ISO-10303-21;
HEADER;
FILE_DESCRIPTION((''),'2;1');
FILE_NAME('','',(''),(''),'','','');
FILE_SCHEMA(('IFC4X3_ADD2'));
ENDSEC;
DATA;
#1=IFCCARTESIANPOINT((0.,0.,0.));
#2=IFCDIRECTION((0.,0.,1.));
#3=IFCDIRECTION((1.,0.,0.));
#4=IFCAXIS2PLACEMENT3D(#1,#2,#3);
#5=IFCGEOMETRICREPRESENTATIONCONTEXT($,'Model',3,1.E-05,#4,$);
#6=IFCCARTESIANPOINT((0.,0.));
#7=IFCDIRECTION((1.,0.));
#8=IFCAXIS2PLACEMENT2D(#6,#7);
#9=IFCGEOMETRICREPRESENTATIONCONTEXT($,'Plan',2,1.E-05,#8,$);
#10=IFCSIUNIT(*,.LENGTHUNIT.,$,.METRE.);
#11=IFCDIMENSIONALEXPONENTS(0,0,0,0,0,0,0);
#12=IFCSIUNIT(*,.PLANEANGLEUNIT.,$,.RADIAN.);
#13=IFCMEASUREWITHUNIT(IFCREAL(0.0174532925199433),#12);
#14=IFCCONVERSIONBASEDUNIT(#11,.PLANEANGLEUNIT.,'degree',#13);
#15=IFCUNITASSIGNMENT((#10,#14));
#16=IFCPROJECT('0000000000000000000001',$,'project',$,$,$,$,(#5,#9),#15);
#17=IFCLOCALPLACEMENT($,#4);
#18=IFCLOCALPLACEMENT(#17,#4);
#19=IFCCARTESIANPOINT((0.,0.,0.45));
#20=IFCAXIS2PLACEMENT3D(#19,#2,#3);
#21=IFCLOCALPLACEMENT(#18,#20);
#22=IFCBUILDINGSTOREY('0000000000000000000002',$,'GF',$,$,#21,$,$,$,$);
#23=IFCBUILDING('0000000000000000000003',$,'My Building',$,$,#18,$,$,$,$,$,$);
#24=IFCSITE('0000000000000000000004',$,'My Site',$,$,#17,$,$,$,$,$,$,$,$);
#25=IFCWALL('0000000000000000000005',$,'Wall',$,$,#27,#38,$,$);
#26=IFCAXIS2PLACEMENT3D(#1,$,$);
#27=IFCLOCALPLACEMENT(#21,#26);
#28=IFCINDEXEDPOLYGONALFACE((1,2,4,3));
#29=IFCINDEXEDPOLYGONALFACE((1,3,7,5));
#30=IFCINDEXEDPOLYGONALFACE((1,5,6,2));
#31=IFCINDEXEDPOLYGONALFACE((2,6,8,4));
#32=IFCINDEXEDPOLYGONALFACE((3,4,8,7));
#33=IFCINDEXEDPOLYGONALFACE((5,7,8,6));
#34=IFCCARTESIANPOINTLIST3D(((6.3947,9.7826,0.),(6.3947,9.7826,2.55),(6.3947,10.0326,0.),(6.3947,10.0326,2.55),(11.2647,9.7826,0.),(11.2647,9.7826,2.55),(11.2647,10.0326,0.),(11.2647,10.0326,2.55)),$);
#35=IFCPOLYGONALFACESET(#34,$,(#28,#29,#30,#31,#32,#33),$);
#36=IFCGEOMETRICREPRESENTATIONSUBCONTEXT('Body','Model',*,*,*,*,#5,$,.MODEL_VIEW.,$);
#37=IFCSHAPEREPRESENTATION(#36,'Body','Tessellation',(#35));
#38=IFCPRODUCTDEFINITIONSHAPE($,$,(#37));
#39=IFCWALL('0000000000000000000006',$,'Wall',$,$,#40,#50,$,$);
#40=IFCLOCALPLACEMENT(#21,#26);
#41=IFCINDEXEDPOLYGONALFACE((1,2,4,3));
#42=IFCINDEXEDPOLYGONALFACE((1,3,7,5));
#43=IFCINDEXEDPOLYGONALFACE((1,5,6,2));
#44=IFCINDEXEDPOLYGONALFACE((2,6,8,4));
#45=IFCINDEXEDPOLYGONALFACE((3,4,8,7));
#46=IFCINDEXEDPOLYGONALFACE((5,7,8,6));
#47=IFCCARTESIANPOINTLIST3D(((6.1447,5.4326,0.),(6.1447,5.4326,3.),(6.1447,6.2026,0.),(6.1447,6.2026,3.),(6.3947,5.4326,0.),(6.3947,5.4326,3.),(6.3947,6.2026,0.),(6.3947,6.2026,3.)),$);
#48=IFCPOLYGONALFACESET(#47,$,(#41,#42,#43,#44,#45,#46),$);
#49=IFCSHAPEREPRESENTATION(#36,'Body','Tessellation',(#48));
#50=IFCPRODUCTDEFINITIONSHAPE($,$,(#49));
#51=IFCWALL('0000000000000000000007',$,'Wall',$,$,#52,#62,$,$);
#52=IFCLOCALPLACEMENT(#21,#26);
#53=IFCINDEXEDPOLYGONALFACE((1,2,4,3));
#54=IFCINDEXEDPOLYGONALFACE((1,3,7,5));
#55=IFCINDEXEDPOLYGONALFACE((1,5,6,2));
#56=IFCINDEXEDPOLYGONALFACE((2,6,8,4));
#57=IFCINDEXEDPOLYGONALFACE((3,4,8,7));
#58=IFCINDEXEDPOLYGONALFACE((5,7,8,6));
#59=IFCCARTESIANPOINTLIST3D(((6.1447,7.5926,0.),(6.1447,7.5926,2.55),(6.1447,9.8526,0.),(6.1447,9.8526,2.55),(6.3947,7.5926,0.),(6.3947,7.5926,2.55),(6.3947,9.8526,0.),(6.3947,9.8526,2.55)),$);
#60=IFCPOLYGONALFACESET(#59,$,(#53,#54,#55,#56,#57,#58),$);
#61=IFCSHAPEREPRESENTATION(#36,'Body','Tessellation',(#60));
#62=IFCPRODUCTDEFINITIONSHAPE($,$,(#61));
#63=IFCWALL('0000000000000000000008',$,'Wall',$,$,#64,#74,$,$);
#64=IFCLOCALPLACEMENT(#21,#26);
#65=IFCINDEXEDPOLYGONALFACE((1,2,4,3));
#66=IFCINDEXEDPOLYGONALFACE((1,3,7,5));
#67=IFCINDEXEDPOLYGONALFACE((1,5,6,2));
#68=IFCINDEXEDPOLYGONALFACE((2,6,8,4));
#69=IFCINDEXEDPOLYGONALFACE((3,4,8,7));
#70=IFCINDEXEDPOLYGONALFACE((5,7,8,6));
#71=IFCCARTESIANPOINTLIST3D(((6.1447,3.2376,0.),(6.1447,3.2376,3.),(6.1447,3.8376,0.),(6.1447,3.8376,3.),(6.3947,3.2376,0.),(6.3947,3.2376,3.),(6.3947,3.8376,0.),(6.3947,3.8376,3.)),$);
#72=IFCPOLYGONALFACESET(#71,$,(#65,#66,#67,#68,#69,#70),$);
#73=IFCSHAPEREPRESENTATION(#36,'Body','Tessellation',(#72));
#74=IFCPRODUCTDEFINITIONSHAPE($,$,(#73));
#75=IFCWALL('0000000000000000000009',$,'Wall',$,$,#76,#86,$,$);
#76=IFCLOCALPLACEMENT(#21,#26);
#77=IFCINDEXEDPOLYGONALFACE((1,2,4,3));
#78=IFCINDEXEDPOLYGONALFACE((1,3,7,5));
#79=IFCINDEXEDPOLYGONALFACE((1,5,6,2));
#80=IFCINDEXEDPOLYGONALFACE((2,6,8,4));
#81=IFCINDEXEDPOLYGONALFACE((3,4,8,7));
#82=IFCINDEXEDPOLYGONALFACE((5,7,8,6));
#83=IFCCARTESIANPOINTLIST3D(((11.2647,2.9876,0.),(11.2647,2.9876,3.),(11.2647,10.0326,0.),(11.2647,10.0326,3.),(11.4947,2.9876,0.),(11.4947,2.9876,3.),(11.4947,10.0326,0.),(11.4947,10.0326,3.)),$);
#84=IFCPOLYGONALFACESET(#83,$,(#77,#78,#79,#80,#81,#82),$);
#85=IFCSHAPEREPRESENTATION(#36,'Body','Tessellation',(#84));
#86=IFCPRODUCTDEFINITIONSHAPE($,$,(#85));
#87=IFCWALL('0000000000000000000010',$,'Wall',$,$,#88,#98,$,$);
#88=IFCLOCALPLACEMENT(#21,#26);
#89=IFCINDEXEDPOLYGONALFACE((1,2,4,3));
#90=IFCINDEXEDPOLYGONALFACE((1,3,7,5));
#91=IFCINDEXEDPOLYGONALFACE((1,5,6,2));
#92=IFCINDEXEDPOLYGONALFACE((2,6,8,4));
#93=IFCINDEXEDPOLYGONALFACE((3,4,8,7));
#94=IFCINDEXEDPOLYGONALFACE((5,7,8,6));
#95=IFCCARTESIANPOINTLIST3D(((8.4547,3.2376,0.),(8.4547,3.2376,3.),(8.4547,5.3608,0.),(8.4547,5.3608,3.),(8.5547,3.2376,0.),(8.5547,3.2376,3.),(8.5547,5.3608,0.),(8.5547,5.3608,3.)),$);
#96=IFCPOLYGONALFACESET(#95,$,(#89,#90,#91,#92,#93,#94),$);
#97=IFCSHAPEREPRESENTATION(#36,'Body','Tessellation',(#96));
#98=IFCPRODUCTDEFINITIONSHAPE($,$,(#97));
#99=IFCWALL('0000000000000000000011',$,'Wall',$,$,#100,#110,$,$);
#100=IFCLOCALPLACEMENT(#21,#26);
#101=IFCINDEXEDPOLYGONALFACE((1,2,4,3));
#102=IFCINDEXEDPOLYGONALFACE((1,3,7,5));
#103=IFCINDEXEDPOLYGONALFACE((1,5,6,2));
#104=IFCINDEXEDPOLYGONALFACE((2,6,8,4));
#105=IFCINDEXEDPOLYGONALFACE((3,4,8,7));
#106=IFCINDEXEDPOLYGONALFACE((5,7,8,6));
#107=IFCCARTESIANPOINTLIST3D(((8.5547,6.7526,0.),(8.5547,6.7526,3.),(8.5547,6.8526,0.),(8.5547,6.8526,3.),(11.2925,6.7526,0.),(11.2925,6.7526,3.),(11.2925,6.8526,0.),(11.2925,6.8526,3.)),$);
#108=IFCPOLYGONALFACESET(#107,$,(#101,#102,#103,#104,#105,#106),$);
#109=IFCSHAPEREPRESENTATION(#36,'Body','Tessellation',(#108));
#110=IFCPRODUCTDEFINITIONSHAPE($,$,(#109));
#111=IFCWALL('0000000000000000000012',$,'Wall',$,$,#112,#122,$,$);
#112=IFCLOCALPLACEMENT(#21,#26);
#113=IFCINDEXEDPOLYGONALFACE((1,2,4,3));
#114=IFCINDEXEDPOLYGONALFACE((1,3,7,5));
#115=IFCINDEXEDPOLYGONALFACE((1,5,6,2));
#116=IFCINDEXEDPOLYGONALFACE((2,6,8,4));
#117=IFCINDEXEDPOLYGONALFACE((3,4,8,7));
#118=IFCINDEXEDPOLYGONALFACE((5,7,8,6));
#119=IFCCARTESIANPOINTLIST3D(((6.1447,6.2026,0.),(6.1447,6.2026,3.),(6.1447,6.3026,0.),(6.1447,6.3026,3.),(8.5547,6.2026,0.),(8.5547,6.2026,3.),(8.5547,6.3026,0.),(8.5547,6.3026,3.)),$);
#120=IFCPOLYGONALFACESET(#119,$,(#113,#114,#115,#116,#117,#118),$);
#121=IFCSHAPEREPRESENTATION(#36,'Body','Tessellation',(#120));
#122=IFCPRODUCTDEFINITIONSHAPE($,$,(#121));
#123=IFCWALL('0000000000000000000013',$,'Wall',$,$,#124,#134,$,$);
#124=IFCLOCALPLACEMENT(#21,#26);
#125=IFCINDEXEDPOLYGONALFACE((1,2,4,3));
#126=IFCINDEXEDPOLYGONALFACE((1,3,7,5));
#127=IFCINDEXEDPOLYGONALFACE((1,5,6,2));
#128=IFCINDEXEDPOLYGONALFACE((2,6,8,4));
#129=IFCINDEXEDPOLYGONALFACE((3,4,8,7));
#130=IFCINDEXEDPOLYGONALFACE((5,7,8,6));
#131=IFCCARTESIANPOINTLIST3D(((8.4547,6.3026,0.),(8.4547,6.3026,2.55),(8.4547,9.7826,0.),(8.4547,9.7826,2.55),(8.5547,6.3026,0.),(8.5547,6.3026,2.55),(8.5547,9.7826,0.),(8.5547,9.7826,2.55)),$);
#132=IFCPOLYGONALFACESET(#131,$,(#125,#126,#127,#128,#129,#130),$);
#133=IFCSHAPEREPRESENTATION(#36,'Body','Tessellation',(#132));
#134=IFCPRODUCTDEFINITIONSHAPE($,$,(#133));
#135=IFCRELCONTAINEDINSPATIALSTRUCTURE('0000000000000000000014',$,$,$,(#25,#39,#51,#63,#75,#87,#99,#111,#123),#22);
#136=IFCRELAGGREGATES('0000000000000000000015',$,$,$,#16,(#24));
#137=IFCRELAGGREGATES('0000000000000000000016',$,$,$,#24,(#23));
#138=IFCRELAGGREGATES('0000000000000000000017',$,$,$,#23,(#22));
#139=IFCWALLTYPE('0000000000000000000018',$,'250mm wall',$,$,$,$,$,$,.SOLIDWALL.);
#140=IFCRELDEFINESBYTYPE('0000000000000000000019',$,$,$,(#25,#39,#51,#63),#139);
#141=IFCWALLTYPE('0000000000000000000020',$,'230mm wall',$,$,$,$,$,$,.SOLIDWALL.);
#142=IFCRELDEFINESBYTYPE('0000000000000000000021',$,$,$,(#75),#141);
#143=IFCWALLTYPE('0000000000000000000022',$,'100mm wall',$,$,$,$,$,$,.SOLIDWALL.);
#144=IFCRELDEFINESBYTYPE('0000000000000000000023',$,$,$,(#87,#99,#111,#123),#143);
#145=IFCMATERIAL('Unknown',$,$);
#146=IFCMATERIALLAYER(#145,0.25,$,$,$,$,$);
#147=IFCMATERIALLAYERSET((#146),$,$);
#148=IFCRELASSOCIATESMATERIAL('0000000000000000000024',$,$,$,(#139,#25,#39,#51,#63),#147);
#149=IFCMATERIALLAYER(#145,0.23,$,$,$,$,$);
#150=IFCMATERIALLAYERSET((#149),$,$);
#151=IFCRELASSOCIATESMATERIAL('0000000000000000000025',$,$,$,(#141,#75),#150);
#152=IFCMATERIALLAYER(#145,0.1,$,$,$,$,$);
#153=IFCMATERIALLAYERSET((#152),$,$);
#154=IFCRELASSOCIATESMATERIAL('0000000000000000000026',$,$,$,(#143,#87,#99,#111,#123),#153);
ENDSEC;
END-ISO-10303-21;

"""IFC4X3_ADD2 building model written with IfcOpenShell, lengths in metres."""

from ifc_helpers import new_model, entity, si_unit, converted_unit, frame, origin_with_axes, origin_2d_with_axis, place, context, subcontext, project, spatial, indexed_curve, outline, extrude, clip, halfspace, material, layer, layer_set, layer_usage, type_object, element, save


model = new_model("IFC4X3_ADD2")

# Units and contexts
model_context = context("Model", 3, precision=1e-05, world=origin_with_axes())
plan_context = context("Plan", 2, precision=1e-05, world=origin_2d_with_axis())
body_context_1 = subcontext(model_context, "Body", "Model", "MODEL_VIEW")
ifc_project = project(units=[si_unit("LENGTHUNIT", "METRE"), converted_unit("PLANEANGLEUNIT", "degree", entity("IfcReal", 0.0174532925199433), si_unit("PLANEANGLEUNIT", "RADIAN"), dimensions=[0, 0, 0, 0, 0, 0, 0])], contexts=[model_context, plan_context])

# Site, building, storey
site_placement = place(None, origin_with_axes())
site = spatial("IfcSite", under=ifc_project, at=site_placement, Name="My Site")
building_placement = place(site_placement, origin_with_axes())
building = spatial("IfcBuilding", under=site, at=building_placement, Name="My Building")
storey_placement = place(building_placement, frame((0.0, 0.0, 0.45), z_axis=(0.0, 0.0, 1.0), x_axis=(1.0, 0.0, 0.0)))
storey = spatial("IfcBuildingStorey", under=building, at=storey_placement, Name="GF")

# Shared definitions
ifc_material_1 = material(Name="Unknown")

# Shared definitions
ifc_layer_1 = layer(ifc_material_1, 0.25)
ifc_layer_set_1 = layer_set([ifc_layer_1])
wall_type_1 = type_object("IfcWallType", Name="250mm wall", PredefinedType="SOLIDWALL", material=ifc_layer_set_1)

# Walls
ifc_layer_usage_1 = layer_usage(ifc_layer_set_1, "AXIS2", "POSITIVE", 0.0)
wall_1_placement = place(storey_placement, frame((6.3947, 9.7826, 0.0), z_axis=(0.0, 0.0, 1.0), x_axis=(1.0, 0.0, 0.0)))
element("IfcWall", 1, at=wall_1_placement, inside=storey, type_object=wall_type_1, material=ifc_layer_usage_1, Name="Wall", context=body_context_1, shape_type="Clipping", body=[
    clip(extrude(outline(indexed_curve([(0.0, 0.0), (0.0, 0.25), (4.87, 0.25), (4.87, 0.0), (0.0, 0.0)], self_intersect=False)), origin_with_axes(), (0.0, 0.0, 1.0), 2.55), halfspace(frame((0.0, 0.0, 2.55), z_axis=(0.0, 0.0, 1.0), x_axis=(-1.0, 0.0, 0.0)), False)),
])
ifc_layer_usage_2 = layer_usage(ifc_layer_set_1, "AXIS2", "POSITIVE", 0.0)
wall_2_placement = place(storey_placement, frame((6.3947, 5.4326, 0.0), z_axis=(0.0, 0.0, 1.0), x_axis=(0.0, 1.0, 0.0)))
element("IfcWall", 2, at=wall_2_placement, inside=storey, type_object=wall_type_1, material=ifc_layer_usage_2, Name="Wall", context=body_context_1, shape_type="SweptSolid", body=[
    extrude(outline(indexed_curve([(0.0, 0.0), (0.0, 0.25), (0.77, 0.25), (0.77, 0.0), (0.0, 0.0)], self_intersect=False)), origin_with_axes(), (0.0, 0.0, 1.0), 3.0),
])
ifc_layer_usage_3 = layer_usage(ifc_layer_set_1, "AXIS2", "POSITIVE", 0.0)
wall_3_placement = place(storey_placement, frame((6.3947, 7.5926, 0.0), z_axis=(0.0, 0.0, 1.0), x_axis=(0.0, 1.0, 0.0)))
element("IfcWall", 3, at=wall_3_placement, inside=storey, type_object=wall_type_1, material=ifc_layer_usage_3, Name="Wall", context=body_context_1, shape_type="Clipping", body=[
    clip(extrude(outline(indexed_curve([(0.0, 0.0), (0.0, 0.25), (2.26, 0.25), (2.26, 0.0), (0.0, 0.0)], self_intersect=False)), origin_with_axes(), (0.0, 0.0, 1.0), 2.55), halfspace(frame((0.0, 0.0, 2.55), z_axis=(0.0, 0.0, 1.0), x_axis=(-1.0, 0.0, 0.0)), False)),
])
ifc_layer_usage_4 = layer_usage(ifc_layer_set_1, "AXIS2", "POSITIVE", 0.0)
wall_4_placement = place(storey_placement, frame((6.3947, 3.2376, 0.0), z_axis=(0.0, 0.0, 1.0), x_axis=(0.0, 1.0, 0.0)))
element("IfcWall", 4, at=wall_4_placement, inside=storey, type_object=wall_type_1, material=ifc_layer_usage_4, Name="Wall", context=body_context_1, shape_type="SweptSolid", body=[
    extrude(outline(indexed_curve([(0.0, 0.0), (0.0, 0.25), (0.6, 0.25), (0.6, 0.0), (0.0, 0.0)], self_intersect=False)), origin_with_axes(), (0.0, 0.0, 1.0), 3.0),
])
ifc_layer_2 = layer(ifc_material_1, 0.23)
ifc_layer_set_2 = layer_set([ifc_layer_2])
ifc_layer_usage_5 = layer_usage(ifc_layer_set_2, "AXIS2", "POSITIVE", 0.0)
wall_type_2 = type_object("IfcWallType", Name="230mm wall", PredefinedType="SOLIDWALL", material=ifc_layer_set_2)
wall_5_placement = place(storey_placement, frame((11.4947, 2.9876, 0.0), z_axis=(0.0, 0.0, 1.0), x_axis=(0.0, 1.0, 0.0)))
element("IfcWall", 5, at=wall_5_placement, inside=storey, type_object=wall_type_2, material=ifc_layer_usage_5, Name="Wall", context=body_context_1, shape_type="SweptSolid", body=[
    extrude(outline(indexed_curve([(0.0, 0.0), (0.0, 0.23), (7.045, 0.23), (7.045, 0.0), (0.0, 0.0)], self_intersect=False)), origin_with_axes(), (0.0, 0.0, 1.0), 3.0),
])
ifc_layer_3 = layer(ifc_material_1, 0.1)
ifc_layer_set_3 = layer_set([ifc_layer_3])
ifc_layer_usage_6 = layer_usage(ifc_layer_set_3, "AXIS2", "POSITIVE", 0.0)
wall_type_3 = type_object("IfcWallType", Name="100mm wall", PredefinedType="SOLIDWALL", material=ifc_layer_set_3)
wall_6_placement = place(storey_placement, frame((8.5547, 3.2376, 0.0), z_axis=(0.0, 0.0, 1.0), x_axis=(0.0, 1.0, 0.0)))
element("IfcWall", 6, at=wall_6_placement, inside=storey, type_object=wall_type_3, material=ifc_layer_usage_6, Name="Wall", context=body_context_1, shape_type="SweptSolid", body=[
    extrude(outline(indexed_curve([(0.0, 0.0), (0.0, 0.1), (2.1232, 0.1), (2.1232, 0.0), (0.0, 0.0)], self_intersect=False)), origin_with_axes(), (0.0, 0.0, 1.0), 3.0),
])
ifc_layer_usage_7 = layer_usage(ifc_layer_set_3, "AXIS2", "POSITIVE", 0.0)
wall_7_placement = place(storey_placement, frame((8.5547, 6.7526, 0.0), z_axis=(0.0, 0.0, 1.0), x_axis=(1.0, 0.0, 0.0)))
element("IfcWall", 7, at=wall_7_placement, inside=storey, type_object=wall_type_3, material=ifc_layer_usage_7, Name="Wall", context=body_context_1, shape_type="SweptSolid", body=[
    extrude(outline(indexed_curve([(0.0, 0.0), (0.0, 0.1), (2.7378, 0.1), (2.7378, 0.0), (0.0, 0.0)], self_intersect=False)), origin_with_axes(), (0.0, 0.0, 1.0), 3.0),
])
ifc_layer_usage_8 = layer_usage(ifc_layer_set_3, "AXIS2", "POSITIVE", 0.0)
wall_8_placement = place(storey_placement, frame((6.1447, 6.2026, 0.0), z_axis=(0.0, 0.0, 1.0), x_axis=(1.0, 0.0, 0.0)))
element("IfcWall", 8, at=wall_8_placement, inside=storey, type_object=wall_type_3, material=ifc_layer_usage_8, Name="Wall", context=body_context_1, shape_type="SweptSolid", body=[
    extrude(outline(indexed_curve([(0.0, 0.0), (0.0, 0.1), (2.41, 0.1), (2.41, 0.0), (0.0, 0.0)], self_intersect=False)), origin_with_axes(), (0.0, 0.0, 1.0), 3.0),
])
ifc_layer_usage_9 = layer_usage(ifc_layer_set_3, "AXIS2", "POSITIVE", 0.0)
wall_9_placement = place(storey_placement, frame((8.5547, 6.3026, 0.0), z_axis=(0.0, 0.0, 1.0), x_axis=(0.0, 1.0, 0.0)))
element("IfcWall", 9, at=wall_9_placement, inside=storey, type_object=wall_type_3, material=ifc_layer_usage_9, Name="Wall", context=body_context_1, shape_type="Clipping", body=[
    clip(extrude(outline(indexed_curve([(0.0, 0.0), (0.0, 0.1), (3.48, 0.1), (3.48, 0.0), (0.0, 0.0)], self_intersect=False)), origin_with_axes(), (0.0, 0.0, 1.0), 2.55), halfspace(frame((0.0, 0.0, 2.55), z_axis=(0.0, 0.0, 1.0), x_axis=(-1.0, 0.0, 0.0)), False)),
])

save(model, "model.ifc")
